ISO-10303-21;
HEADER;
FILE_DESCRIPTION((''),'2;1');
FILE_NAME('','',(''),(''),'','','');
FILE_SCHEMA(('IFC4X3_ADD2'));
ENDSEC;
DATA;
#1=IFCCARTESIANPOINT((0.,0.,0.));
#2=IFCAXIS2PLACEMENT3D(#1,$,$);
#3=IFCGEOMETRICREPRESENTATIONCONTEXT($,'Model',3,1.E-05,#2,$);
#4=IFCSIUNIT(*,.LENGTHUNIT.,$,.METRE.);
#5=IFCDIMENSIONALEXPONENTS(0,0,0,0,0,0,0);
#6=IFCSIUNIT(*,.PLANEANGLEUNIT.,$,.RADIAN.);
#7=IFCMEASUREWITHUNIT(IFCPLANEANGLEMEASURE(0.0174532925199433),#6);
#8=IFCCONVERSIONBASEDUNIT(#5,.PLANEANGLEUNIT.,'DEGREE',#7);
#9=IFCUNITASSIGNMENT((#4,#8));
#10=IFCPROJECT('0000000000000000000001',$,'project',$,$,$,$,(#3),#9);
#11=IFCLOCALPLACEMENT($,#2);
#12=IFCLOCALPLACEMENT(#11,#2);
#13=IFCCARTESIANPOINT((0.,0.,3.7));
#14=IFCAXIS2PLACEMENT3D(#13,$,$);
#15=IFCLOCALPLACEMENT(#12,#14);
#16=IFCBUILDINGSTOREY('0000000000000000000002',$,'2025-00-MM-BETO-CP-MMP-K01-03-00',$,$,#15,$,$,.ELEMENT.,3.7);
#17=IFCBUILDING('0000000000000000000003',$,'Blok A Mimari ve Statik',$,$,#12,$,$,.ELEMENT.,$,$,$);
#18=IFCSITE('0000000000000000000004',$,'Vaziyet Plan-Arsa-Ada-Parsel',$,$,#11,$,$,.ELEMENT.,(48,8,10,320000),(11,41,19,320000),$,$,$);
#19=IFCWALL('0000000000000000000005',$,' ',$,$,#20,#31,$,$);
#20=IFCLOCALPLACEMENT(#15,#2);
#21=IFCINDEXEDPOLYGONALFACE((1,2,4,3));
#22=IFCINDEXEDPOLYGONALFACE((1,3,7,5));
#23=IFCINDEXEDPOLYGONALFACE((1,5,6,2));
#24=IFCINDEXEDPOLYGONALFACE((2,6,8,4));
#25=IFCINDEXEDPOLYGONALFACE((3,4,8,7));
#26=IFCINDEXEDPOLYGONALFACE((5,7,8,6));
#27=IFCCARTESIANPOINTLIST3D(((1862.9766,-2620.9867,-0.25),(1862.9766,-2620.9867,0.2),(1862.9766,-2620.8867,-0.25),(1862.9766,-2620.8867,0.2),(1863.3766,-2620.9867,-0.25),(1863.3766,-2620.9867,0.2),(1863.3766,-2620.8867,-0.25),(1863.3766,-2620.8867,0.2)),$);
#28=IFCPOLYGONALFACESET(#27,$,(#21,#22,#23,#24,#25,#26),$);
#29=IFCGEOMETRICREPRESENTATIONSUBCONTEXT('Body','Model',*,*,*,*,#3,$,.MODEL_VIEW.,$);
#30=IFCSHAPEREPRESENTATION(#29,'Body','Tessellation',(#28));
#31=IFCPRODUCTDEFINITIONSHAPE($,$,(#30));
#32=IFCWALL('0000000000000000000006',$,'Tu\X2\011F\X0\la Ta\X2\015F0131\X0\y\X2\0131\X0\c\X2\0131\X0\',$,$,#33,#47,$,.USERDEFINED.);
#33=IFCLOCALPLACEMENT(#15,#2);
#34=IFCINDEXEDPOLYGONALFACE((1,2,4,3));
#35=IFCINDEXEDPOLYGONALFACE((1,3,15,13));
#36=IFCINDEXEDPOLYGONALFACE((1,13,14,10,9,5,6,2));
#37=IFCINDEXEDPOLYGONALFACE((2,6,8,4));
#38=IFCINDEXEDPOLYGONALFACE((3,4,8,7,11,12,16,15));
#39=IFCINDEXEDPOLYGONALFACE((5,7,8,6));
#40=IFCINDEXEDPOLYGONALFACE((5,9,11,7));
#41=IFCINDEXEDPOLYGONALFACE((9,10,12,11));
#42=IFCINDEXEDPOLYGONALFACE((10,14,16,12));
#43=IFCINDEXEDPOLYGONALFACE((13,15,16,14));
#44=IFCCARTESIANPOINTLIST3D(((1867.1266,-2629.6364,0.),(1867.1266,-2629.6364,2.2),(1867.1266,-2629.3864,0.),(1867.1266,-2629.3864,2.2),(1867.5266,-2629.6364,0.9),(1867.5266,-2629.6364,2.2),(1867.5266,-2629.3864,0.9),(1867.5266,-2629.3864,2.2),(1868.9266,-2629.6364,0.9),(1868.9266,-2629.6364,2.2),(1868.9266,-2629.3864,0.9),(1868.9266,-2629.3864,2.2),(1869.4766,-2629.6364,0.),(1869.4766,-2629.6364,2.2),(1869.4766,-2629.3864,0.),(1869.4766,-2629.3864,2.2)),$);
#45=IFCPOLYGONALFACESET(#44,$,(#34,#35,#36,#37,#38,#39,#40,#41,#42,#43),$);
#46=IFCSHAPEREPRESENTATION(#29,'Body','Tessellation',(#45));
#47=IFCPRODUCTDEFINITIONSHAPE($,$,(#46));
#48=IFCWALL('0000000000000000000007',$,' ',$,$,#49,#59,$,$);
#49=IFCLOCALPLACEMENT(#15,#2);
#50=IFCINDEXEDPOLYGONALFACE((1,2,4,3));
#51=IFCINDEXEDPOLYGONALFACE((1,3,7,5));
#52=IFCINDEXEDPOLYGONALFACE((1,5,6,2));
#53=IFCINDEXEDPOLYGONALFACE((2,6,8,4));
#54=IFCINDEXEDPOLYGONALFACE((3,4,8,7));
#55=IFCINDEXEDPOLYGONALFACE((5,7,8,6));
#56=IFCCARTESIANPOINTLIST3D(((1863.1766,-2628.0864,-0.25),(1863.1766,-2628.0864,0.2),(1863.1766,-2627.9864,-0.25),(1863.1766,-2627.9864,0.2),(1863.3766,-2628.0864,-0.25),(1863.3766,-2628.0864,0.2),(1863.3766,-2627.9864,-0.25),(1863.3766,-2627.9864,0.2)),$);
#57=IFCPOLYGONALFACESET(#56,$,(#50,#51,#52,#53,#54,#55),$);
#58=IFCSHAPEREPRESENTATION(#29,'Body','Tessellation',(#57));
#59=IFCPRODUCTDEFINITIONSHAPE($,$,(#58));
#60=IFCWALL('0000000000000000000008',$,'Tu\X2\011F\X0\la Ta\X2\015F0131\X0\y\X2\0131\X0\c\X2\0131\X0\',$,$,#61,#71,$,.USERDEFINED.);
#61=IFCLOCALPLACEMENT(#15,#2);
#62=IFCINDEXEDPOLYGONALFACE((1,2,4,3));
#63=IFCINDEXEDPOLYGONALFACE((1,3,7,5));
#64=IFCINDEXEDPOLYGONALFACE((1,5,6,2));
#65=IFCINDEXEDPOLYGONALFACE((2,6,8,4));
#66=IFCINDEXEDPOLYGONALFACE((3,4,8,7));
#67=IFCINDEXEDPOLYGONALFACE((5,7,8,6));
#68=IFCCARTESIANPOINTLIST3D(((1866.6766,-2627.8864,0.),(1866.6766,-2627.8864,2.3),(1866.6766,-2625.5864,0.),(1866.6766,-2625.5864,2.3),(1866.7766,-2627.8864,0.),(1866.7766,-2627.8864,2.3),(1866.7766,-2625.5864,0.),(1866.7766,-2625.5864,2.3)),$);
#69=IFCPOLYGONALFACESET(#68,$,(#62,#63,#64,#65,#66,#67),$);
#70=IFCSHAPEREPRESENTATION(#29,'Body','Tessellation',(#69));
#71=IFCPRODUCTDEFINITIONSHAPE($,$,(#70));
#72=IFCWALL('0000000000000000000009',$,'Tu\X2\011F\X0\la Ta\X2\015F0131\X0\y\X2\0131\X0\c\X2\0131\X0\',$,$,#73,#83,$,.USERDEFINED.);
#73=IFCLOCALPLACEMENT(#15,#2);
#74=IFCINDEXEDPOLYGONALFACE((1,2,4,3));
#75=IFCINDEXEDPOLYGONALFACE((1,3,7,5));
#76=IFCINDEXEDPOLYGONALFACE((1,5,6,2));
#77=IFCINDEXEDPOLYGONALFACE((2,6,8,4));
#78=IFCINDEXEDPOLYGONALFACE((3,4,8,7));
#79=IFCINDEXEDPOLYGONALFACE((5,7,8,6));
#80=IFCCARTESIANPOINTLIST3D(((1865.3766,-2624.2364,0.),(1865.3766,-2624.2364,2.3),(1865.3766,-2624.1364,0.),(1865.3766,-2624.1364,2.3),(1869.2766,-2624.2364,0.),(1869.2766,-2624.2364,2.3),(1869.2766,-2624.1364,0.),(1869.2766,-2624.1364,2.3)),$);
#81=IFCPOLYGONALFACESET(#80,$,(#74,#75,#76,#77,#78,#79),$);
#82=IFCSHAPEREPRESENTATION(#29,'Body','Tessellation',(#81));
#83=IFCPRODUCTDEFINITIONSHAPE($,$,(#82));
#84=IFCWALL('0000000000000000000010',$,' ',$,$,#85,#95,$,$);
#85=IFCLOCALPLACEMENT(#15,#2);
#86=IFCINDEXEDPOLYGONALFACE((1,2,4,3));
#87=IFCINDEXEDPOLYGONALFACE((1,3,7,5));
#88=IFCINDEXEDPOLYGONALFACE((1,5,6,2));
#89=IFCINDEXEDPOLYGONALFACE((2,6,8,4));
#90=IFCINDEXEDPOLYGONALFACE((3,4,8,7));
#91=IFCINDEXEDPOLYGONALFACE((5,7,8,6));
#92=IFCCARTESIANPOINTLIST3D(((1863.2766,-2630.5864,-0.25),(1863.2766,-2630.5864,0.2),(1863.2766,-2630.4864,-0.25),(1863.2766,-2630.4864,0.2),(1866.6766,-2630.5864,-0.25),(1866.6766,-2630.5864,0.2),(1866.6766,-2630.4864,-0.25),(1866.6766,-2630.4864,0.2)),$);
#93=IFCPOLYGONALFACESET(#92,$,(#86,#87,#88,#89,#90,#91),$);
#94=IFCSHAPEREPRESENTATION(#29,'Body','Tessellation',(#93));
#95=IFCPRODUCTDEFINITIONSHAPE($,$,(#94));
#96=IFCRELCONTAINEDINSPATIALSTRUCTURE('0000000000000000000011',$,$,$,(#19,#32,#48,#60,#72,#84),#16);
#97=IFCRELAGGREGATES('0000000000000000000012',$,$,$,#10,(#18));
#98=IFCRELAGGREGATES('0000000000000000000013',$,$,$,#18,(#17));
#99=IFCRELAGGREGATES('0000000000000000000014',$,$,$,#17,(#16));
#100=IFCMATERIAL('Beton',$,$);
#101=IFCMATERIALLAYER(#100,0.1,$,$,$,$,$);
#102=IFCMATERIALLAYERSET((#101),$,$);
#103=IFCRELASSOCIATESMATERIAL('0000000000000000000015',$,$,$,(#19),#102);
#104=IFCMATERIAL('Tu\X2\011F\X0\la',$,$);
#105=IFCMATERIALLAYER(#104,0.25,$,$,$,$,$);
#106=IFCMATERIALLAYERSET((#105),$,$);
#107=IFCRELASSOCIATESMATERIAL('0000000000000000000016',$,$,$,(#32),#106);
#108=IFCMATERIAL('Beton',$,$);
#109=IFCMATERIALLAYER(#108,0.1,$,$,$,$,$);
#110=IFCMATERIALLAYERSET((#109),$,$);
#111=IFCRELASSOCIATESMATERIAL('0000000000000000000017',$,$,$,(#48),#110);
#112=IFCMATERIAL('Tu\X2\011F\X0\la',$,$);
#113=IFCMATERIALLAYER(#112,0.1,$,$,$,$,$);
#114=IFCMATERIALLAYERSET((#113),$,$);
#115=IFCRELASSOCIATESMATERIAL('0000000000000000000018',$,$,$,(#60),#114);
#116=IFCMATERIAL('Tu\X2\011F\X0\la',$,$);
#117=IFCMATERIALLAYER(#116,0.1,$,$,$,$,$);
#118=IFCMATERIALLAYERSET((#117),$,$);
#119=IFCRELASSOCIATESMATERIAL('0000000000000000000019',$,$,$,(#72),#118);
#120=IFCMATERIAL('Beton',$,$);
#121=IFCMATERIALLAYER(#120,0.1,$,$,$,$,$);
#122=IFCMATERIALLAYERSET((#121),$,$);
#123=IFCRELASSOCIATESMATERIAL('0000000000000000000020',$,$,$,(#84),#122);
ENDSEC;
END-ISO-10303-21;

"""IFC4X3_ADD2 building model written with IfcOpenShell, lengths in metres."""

from ifc_helpers import new_model, entity, si_unit, converted_unit, frame, frame_2d, origin, origin_with_axes, place, context, subcontext, project, spatial, polyline, rectangle, outline, extrude, material, layer, layer_set, layer_usage, element, save


model = new_model("IFC4X3_ADD2")

# Units and contexts
model_context = context("Model", 3, precision=1e-05, world=origin())
body_context = subcontext(model_context, "Body", "Model", "MODEL_VIEW")
ifc_project = project(units=[si_unit("LENGTHUNIT", "METRE"), converted_unit("PLANEANGLEUNIT", "DEGREE", entity("IfcPlaneAngleMeasure", 0.0174532925199433), si_unit("PLANEANGLEUNIT", "RADIAN"), dimensions=[0, 0, 0, 0, 0, 0, 0])], contexts=[model_context])

# Site, building, storey
site_placement = place(None, origin())
site = spatial("IfcSite", under=ifc_project, at=site_placement, Name="Vaziyet Plan-Arsa-Ada-Parsel", CompositionType="ELEMENT", RefLatitude=(48, 8, 10, 320000), RefLongitude=(11, 41, 19, 320000))
building_placement = place(site_placement, origin())
building = spatial("IfcBuilding", under=site, at=building_placement, Name="Blok A Mimari ve Statik", CompositionType="ELEMENT")
storey_placement = place(building_placement, frame((0.0, 0.0, 3.7)))
storey = spatial("IfcBuildingStorey", under=building, at=storey_placement, Name="2025-00-MM-BETO-CP-MMP-K01-03-00", CompositionType="ELEMENT", Elevation=3.7)

# Wall
ifc_material_1 = material(Name="Beton")
ifc_layer_1 = layer(ifc_material_1, 0.1)
ifc_layer_set_1 = layer_set([ifc_layer_1])
ifc_layer_usage_1 = layer_usage(ifc_layer_set_1, "AXIS2", "POSITIVE", 0.0)
wall_1_placement = place(storey_placement, frame((1863.3766, -2620.8867, -0.25), z_axis=(0.0, 0.0, 1.0), x_axis=(-1.0, 0.0, 0.0)))
element("IfcWall", 1, at=wall_1_placement, inside=storey, material=ifc_layer_usage_1, Name=" ", context=body_context, shape_type="SweptSolid", body=[
    extrude(rectangle(XDim=0.4, YDim=0.1, at=frame_2d((0.2, 0.05), x_axis=(1.0, 0.0))), origin_with_axes(), (0.0, 0.0, 1.0), 0.45),
])

# Wall, opening
ifc_material_2 = material(Name="Tuğla")
ifc_layer_2 = layer(ifc_material_2, 0.25)
ifc_layer_set_2 = layer_set([ifc_layer_2])
ifc_layer_usage_2 = layer_usage(ifc_layer_set_2, "AXIS2", "POSITIVE", 0.0)
wall_2_placement = place(storey_placement, frame((1867.1266, -2629.6364, 0.0)))
wall_2 = element("IfcWall", 2, at=wall_2_placement, inside=storey, material=ifc_layer_usage_2, Name="Tuğla Taşıyıcı", PredefinedType="USERDEFINED", context=body_context, shape_type="SweptSolid", body=[
    extrude(rectangle(XDim=2.35, YDim=0.25, at=frame_2d((1.175, 0.125), x_axis=(1.0, 0.0))), origin_with_axes(), (0.0, 0.0, 1.0), 2.2),
])
opening_1_placement = place(wall_2_placement, frame((0.4, 0.0, 0.9), z_axis=(0.0, 1.0, 0.0), x_axis=(0.0, 0.0, 1.0)))
element("IfcOpeningElement", 3, at=opening_1_placement, cuts=wall_2, PredefinedType="OPENING", context=body_context, shape_type="SweptSolid", body=[
    extrude(outline(polyline([(1.35, 1.4), (1.35, 0.0), (0.0, 0.0), (0.0, 1.4), (1.35, 1.4)])), origin_with_axes(), (0.0, 0.0, 1.0), 0.25),
])

# Walls
ifc_material_3 = material(Name="Beton")
ifc_layer_3 = layer(ifc_material_3, 0.1)
ifc_layer_set_3 = layer_set([ifc_layer_3])
ifc_layer_usage_3 = layer_usage(ifc_layer_set_3, "AXIS2", "POSITIVE", 0.0)
wall_3_placement = place(storey_placement, frame((1863.3766, -2627.9864, -0.25), z_axis=(0.0, 0.0, 1.0), x_axis=(-1.0, 0.0, 0.0)))
element("IfcWall", 4, at=wall_3_placement, inside=storey, material=ifc_layer_usage_3, Name=" ", context=body_context, shape_type="SweptSolid", body=[
    extrude(rectangle(XDim=0.2, YDim=0.1, at=frame_2d((0.1, 0.05), x_axis=(1.0, 0.0))), origin_with_axes(), (0.0, 0.0, 1.0), 0.45),
])
ifc_material_4 = material(Name="Tuğla")
ifc_layer_4 = layer(ifc_material_4, 0.1)
ifc_layer_set_4 = layer_set([ifc_layer_4])
ifc_layer_usage_4 = layer_usage(ifc_layer_set_4, "AXIS2", "POSITIVE", 0.0)
wall_4_placement = place(storey_placement, frame((1866.6766, -2625.5864, 0.0), z_axis=(0.0, 0.0, 1.0), x_axis=(0.0, -1.0, 0.0)))
element("IfcWall", 5, at=wall_4_placement, inside=storey, material=ifc_layer_usage_4, Name="Tuğla Taşıyıcı", PredefinedType="USERDEFINED", context=body_context, shape_type="SweptSolid", body=[
    extrude(rectangle(XDim=2.3, YDim=0.1, at=frame_2d((1.15, 0.05), x_axis=(1.0, 0.0))), origin_with_axes(), (0.0, 0.0, 1.0), 2.3),
])
ifc_material_5 = material(Name="Tuğla")
ifc_layer_5 = layer(ifc_material_5, 0.1)
ifc_layer_set_5 = layer_set([ifc_layer_5])
ifc_layer_usage_5 = layer_usage(ifc_layer_set_5, "AXIS2", "POSITIVE", 0.0)
wall_5_placement = place(storey_placement, frame((1865.3766, -2624.2364, 0.0), z_axis=(0.0, 0.0, 1.0), x_axis=(1.0, 0.0, 0.0)))
element("IfcWall", 6, at=wall_5_placement, inside=storey, material=ifc_layer_usage_5, Name="Tuğla Taşıyıcı", PredefinedType="USERDEFINED", context=body_context, shape_type="SweptSolid", body=[
    extrude(rectangle(XDim=3.9, YDim=0.1, at=frame_2d((1.95, 0.05), x_axis=(1.0, 0.0))), origin_with_axes(), (0.0, 0.0, 1.0), 2.3),
])
ifc_material_6 = material(Name="Beton")
ifc_layer_6 = layer(ifc_material_6, 0.1)
ifc_layer_set_6 = layer_set([ifc_layer_6])
ifc_layer_usage_6 = layer_usage(ifc_layer_set_6, "AXIS2", "POSITIVE", 0.0)
wall_6_placement = place(storey_placement, frame((1863.2766, -2630.5864, -0.25)))
element("IfcWall", 7, at=wall_6_placement, inside=storey, material=ifc_layer_usage_6, Name=" ", context=body_context, shape_type="SweptSolid", body=[
    extrude(rectangle(XDim=3.4, YDim=0.1, at=frame_2d((1.7, 0.05), x_axis=(1.0, 0.0))), origin_with_axes(), (0.0, 0.0, 1.0), 0.45),
])

save(model, "model.ifc")
